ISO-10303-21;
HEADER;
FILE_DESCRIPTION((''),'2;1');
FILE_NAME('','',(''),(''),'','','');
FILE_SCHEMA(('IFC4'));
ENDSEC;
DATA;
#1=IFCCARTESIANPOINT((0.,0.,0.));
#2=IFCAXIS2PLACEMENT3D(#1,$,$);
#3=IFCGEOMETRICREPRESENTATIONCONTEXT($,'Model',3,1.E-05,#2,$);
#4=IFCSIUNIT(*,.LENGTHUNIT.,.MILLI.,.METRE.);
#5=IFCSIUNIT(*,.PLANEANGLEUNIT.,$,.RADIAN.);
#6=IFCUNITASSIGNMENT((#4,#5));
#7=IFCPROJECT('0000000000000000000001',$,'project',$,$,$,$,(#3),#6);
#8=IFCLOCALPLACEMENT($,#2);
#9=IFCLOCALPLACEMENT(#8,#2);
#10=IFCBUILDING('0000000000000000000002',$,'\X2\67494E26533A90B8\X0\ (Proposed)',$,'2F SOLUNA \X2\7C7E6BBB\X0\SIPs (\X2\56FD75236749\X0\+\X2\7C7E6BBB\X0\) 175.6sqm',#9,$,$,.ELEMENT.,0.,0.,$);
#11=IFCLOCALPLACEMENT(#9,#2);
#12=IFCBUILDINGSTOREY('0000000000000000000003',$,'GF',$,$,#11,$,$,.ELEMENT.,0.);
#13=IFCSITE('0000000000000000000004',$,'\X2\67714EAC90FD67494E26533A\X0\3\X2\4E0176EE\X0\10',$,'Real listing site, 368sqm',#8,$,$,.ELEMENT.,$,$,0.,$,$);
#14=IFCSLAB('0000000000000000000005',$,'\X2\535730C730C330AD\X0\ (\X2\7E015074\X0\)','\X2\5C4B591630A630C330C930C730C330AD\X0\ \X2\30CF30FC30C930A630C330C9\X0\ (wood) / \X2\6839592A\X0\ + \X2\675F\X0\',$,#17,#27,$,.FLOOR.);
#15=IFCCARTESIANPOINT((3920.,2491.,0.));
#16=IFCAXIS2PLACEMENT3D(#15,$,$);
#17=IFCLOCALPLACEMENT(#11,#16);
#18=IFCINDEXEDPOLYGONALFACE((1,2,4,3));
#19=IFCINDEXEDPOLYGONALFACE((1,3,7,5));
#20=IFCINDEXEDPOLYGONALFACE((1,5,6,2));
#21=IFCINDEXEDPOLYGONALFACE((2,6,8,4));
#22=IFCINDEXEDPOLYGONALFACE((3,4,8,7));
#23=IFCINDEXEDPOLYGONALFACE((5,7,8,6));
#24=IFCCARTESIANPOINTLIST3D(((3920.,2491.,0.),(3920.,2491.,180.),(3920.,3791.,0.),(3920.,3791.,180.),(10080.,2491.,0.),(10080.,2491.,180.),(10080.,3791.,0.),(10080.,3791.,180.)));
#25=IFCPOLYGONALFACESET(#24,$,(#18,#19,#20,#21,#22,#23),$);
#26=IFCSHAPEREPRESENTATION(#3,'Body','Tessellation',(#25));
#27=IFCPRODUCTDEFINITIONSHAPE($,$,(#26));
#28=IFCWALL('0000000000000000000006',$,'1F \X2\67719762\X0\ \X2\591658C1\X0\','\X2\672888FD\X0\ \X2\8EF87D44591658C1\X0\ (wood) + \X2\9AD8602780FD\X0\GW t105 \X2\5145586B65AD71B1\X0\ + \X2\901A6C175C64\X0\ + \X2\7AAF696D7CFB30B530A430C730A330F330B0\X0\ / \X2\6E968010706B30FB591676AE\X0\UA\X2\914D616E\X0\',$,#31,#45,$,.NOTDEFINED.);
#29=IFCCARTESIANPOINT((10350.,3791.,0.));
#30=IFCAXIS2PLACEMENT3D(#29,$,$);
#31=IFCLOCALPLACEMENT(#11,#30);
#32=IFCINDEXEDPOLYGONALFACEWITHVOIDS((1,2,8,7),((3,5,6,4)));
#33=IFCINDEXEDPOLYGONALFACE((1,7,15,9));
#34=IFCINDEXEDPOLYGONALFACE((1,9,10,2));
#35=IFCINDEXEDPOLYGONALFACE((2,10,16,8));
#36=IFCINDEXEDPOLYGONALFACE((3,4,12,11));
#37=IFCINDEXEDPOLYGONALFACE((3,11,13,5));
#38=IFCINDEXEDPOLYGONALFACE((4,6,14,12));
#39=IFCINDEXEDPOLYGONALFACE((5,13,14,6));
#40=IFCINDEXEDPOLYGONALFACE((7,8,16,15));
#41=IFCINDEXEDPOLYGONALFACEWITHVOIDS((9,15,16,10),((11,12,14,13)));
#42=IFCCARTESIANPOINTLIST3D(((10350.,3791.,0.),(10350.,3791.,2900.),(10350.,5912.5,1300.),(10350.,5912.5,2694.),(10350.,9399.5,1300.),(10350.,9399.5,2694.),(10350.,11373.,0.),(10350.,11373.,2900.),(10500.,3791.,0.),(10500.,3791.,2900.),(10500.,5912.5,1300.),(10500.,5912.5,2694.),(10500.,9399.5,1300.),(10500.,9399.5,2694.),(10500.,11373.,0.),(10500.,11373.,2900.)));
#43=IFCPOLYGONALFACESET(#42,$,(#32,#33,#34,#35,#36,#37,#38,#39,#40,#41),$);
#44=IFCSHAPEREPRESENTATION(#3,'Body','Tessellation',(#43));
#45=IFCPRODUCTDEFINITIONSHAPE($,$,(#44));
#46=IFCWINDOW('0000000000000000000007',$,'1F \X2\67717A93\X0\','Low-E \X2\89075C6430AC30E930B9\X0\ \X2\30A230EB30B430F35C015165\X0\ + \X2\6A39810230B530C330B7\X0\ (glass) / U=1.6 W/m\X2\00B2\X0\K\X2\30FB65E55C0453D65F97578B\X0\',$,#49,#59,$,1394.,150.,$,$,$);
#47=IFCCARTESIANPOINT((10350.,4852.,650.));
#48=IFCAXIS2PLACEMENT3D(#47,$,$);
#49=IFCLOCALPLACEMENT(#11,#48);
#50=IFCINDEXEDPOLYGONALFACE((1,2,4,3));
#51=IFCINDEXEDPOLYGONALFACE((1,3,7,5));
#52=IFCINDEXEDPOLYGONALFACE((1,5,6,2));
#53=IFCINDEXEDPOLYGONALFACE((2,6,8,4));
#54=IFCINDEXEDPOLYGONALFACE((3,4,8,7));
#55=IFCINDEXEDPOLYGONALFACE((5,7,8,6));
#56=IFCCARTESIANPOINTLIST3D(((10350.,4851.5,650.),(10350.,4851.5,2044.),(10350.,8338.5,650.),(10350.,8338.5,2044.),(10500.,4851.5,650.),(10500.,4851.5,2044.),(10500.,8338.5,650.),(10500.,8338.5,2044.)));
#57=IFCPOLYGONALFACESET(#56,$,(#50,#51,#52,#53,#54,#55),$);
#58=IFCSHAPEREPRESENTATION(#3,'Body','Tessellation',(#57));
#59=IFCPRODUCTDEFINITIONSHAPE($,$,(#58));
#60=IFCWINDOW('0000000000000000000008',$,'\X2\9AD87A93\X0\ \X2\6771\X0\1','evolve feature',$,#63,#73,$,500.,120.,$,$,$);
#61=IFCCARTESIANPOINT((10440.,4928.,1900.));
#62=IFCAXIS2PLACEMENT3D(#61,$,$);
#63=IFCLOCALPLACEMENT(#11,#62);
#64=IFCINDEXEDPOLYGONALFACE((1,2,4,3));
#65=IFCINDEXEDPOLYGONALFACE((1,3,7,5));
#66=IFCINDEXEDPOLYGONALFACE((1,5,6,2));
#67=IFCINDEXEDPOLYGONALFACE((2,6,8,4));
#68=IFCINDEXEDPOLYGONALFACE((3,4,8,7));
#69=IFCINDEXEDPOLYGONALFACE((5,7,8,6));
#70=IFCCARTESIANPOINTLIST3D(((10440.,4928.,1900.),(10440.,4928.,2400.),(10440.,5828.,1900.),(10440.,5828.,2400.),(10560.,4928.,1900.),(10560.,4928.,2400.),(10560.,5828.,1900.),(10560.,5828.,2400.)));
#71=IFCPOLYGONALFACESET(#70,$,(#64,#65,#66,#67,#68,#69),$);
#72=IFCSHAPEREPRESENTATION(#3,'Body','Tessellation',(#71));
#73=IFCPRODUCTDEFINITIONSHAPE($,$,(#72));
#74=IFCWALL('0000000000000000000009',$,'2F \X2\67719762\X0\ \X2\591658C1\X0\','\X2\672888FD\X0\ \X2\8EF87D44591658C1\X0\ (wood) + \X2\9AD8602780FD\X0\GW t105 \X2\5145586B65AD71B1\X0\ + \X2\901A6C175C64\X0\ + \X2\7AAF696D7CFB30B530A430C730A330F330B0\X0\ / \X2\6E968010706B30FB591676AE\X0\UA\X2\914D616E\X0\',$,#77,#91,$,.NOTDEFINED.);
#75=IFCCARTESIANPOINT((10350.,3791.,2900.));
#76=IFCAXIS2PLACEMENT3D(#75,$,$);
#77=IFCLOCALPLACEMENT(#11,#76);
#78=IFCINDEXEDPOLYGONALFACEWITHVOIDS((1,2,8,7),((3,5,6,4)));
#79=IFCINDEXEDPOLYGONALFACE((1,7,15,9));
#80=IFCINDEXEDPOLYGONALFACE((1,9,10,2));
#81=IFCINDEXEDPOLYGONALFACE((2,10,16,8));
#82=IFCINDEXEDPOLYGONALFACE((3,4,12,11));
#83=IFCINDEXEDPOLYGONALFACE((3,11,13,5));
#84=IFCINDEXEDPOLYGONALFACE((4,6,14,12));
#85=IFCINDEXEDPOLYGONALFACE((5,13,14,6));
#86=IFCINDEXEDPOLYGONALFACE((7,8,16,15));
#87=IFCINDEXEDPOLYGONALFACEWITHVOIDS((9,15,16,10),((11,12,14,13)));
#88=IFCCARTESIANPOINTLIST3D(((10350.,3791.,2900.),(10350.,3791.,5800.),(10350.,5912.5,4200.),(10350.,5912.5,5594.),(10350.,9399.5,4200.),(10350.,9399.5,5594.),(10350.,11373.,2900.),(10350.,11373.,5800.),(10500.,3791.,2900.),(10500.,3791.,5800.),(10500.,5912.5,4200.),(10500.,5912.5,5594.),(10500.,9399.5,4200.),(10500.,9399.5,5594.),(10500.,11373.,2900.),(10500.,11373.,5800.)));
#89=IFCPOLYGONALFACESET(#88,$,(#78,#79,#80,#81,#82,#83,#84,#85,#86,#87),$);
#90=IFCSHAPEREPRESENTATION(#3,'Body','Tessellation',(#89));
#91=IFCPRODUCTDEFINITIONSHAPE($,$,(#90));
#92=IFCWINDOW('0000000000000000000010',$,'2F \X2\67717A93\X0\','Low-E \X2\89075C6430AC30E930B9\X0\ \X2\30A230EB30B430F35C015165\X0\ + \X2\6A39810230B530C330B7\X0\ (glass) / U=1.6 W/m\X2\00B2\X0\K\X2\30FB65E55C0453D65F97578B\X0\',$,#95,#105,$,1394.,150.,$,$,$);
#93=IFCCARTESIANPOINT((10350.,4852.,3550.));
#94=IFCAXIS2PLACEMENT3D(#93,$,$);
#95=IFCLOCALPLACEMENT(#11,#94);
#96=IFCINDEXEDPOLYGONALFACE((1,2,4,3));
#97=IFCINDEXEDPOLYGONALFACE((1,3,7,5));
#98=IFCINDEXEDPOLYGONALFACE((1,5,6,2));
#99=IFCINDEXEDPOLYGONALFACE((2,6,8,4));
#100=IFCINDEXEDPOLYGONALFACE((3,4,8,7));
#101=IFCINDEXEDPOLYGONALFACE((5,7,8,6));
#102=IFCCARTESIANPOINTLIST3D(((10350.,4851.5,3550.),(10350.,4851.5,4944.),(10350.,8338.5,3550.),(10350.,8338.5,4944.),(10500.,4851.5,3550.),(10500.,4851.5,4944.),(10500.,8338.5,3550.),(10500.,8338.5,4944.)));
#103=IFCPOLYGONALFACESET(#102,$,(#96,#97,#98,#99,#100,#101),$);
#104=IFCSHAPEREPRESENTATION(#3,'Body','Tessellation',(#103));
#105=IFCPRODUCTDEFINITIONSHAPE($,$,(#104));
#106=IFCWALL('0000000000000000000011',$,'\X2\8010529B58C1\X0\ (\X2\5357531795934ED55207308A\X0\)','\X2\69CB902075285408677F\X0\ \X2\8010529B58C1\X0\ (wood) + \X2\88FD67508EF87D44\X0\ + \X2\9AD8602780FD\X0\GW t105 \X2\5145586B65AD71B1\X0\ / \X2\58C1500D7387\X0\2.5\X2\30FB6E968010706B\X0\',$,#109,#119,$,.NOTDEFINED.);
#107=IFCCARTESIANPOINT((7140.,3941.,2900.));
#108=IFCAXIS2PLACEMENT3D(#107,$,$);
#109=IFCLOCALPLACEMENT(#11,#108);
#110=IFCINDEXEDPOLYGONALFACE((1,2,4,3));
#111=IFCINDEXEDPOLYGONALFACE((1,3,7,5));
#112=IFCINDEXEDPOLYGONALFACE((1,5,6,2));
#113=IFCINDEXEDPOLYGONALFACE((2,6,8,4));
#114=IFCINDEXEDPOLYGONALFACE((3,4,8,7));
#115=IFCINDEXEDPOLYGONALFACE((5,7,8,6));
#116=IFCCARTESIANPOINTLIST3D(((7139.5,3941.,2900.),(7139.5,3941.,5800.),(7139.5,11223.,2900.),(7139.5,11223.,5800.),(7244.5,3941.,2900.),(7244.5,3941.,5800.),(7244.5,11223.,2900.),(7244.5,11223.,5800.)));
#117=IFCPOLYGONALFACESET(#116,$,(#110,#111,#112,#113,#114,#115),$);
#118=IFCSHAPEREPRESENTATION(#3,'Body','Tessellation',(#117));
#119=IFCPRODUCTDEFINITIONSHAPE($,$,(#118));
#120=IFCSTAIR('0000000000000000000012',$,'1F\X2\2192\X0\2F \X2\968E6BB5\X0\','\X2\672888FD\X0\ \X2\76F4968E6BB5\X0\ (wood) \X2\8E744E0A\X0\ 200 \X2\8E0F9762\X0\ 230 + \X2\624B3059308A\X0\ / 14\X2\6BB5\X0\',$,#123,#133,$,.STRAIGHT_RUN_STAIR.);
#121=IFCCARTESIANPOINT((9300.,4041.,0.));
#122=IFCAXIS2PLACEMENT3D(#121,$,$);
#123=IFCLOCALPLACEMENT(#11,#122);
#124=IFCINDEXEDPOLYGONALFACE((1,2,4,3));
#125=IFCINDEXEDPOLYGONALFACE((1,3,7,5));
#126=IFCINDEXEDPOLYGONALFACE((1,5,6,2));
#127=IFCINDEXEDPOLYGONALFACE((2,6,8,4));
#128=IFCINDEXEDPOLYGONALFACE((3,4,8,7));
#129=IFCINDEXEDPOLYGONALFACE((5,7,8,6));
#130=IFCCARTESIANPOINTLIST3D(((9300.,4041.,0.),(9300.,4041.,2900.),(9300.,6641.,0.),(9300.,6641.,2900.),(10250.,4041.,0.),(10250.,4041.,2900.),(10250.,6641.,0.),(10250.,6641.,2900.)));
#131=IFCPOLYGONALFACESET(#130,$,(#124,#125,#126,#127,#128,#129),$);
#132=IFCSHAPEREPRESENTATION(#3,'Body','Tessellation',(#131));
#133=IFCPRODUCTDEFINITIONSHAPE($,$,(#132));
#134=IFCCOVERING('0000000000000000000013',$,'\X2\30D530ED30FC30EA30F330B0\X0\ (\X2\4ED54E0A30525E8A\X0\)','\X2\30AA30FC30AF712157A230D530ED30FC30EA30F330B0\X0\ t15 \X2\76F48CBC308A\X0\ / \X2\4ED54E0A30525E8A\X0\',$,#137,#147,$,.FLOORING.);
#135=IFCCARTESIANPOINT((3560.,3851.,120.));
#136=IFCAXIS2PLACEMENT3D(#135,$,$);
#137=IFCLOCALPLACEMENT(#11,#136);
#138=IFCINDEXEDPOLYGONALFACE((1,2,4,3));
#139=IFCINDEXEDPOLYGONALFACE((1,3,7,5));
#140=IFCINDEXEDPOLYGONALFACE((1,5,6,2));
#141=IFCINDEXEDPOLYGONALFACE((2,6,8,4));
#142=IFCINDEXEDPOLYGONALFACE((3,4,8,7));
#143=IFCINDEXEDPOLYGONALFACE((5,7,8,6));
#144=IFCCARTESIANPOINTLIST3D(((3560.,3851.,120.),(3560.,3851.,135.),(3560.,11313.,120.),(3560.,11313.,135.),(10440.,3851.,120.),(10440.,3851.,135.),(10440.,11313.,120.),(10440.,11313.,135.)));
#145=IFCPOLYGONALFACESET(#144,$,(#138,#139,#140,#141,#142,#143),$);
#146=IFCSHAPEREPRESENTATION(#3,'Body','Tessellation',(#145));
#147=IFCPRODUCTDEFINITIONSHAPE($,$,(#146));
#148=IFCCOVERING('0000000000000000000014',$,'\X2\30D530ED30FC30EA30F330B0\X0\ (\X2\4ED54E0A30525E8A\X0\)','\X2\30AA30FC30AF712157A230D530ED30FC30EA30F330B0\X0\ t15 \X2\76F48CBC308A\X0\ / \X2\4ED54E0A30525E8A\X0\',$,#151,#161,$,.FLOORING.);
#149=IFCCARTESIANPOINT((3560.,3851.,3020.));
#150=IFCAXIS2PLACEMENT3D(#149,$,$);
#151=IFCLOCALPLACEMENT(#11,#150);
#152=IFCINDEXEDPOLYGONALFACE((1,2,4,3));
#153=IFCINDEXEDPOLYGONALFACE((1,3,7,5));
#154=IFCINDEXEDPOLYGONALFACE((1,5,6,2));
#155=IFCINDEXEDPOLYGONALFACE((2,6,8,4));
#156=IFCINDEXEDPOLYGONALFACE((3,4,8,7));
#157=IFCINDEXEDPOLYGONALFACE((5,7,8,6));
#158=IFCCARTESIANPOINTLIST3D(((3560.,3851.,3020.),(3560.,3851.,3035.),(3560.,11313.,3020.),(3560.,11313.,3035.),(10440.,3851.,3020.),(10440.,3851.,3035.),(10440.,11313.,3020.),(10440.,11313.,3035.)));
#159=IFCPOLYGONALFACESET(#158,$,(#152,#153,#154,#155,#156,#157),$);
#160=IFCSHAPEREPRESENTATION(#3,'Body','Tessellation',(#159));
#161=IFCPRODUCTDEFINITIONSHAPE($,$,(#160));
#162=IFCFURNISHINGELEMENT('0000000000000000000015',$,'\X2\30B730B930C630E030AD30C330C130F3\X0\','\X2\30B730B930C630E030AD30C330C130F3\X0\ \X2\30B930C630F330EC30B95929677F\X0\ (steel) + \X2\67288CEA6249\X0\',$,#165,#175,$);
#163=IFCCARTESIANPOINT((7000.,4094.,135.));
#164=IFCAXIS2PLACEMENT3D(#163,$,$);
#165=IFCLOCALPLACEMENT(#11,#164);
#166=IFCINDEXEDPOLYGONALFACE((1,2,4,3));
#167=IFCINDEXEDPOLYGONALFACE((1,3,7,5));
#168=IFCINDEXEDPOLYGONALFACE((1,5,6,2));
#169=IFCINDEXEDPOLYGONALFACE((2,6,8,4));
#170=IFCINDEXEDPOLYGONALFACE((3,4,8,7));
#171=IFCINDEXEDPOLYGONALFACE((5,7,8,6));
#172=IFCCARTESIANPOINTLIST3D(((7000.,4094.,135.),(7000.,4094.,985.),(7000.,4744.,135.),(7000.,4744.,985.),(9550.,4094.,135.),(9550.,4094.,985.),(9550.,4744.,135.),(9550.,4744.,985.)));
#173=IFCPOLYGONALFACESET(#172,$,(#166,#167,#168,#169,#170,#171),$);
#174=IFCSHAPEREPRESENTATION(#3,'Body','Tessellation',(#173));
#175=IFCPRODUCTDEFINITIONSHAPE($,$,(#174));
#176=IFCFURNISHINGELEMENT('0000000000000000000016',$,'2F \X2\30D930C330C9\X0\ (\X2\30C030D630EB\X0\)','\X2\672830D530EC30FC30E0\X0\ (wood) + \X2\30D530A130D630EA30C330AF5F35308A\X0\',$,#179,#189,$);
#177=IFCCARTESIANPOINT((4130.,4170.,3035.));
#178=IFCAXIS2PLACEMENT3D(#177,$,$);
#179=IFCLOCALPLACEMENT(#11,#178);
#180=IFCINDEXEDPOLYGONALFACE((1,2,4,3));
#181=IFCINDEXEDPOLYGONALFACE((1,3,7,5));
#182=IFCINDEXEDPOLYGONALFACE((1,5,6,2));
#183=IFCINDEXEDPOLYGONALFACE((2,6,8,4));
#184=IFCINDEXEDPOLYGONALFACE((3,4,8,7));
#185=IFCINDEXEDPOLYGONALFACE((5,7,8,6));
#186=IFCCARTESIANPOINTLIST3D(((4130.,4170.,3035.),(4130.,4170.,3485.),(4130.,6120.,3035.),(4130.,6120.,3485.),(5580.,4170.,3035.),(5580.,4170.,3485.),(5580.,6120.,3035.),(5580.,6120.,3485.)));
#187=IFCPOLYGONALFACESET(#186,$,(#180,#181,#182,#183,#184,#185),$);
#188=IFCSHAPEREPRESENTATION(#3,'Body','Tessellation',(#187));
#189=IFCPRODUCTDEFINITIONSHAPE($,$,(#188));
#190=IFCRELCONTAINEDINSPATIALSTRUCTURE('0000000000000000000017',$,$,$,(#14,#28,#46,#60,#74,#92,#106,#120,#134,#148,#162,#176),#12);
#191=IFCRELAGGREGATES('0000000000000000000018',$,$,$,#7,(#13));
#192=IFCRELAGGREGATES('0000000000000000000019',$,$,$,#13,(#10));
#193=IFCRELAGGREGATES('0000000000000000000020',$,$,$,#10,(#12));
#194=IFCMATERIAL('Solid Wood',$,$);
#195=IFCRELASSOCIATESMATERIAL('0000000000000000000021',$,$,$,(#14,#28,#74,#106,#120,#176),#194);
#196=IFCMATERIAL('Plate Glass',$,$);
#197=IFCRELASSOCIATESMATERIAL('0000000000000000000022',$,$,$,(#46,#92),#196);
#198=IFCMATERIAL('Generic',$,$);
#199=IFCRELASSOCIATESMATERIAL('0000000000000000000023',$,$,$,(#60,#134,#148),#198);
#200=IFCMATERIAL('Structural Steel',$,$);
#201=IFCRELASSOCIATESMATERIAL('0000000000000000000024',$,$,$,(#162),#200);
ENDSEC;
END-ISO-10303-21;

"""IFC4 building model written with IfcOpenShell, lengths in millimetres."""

from ifc_helpers import new_model, si_unit, frame, frame_2d, origin, place, context, project, spatial, rectangle, extrude, material, element, fill, save


model = new_model("IFC4")

# Units and contexts
model_context = context("Model", 3, precision=1e-05, world=origin())
ifc_project = project(units=[si_unit("LENGTHUNIT", "METRE", prefix="MILLI"), si_unit("PLANEANGLEUNIT", "RADIAN")], contexts=[model_context])

# Site, building, storey
site_placement = place(None, origin())
site = spatial("IfcSite", under=ifc_project, at=site_placement, Name="東京都杉並区3丁目10", ObjectType="Real listing site, 368sqm", CompositionType="ELEMENT", RefElevation=0.0)
building_placement = place(site_placement, origin())
building = spatial("IfcBuilding", under=site, at=building_placement, Name="杉並区邸 (Proposed)", ObjectType="2F SOLUNA 籾殻SIPs (国産杉+籾殻) 175.6sqm", CompositionType="ELEMENT", ElevationOfRefHeight=0.0, ElevationOfTerrain=0.0)
storey_placement = place(building_placement, origin())
storey = spatial("IfcBuildingStorey", under=building, at=storey_placement, Name="GF", CompositionType="ELEMENT", Elevation=0.0)

# Slab
ifc_material_1 = material(Name="Solid Wood")
slab_placement = place(storey_placement, frame((3920.0, 2491.0, 0.0)))
element("IfcSlab", 1, at=slab_placement, inside=storey, material=ifc_material_1, Name="南デッキ (縁側)", Description="屋外ウッドデッキ ハードウッド (wood) / 根太 + 束", PredefinedType="FLOOR", context=model_context, shape_type="SweptSolid", body=[
    extrude(rectangle(XDim=6160.0, YDim=1300.0, at=frame_2d((3080.0, 650.0))), frame((3920.0, 2491.0, 0.0)), (0.0, 0.0, 1.0), 180.0),
])

# Wall, openings, windows
wall_1_placement = place(storey_placement, frame((10350.0, 3791.0, 0.0)))
wall_1 = element("IfcWall", 2, at=wall_1_placement, inside=storey, material=ifc_material_1, Name="1F 東面 外壁", Description="木製 軸組外壁 (wood) + 高性能GW t105 充填断熱 + 通気層 + 窯業系サイディング / 準耐火・外皮UA配慮", PredefinedType="NOTDEFINED", context=model_context, shape_type="SweptSolid", body=[
    extrude(rectangle(XDim=150.0, YDim=7582.0, at=frame_2d((75.0, 3791.0))), frame((10350.0, 3791.0, 0.0)), (0.0, 0.0, 1.0), 2900.0),
])
opening_1_placement = place(storey_placement, frame((10350.0, 4852.0, 650.0)))
opening_1 = element("IfcOpeningElement", 3, at=opening_1_placement, cuts=wall_1, PredefinedType="NOTDEFINED", context=model_context, shape_type="SweptSolid", body=[
    extrude(rectangle(XDim=150.0, YDim=3487.0, at=frame_2d((75.0, 1743.0))), frame((10350.0, 4852.0, 650.0)), (0.0, 0.0, 1.0), 1394.0),
])
opening_2_placement = place(storey_placement, frame((10440.0, 4928.0, 1900.0)))
opening_2 = element("IfcOpeningElement", 4, at=opening_2_placement, cuts=wall_1, PredefinedType="NOTDEFINED", context=model_context, shape_type="SweptSolid", body=[
    extrude(rectangle(XDim=120.0, YDim=900.0, at=frame_2d((60.0, 450.0))), frame((10440.0, 4928.0, 1900.0)), (0.0, 0.0, 1.0), 500.0),
])
ifc_material_2 = material(Name="Plate Glass")
window_1_placement = place(storey_placement, frame((10350.0, 4852.0, 650.0)))
window_1 = element("IfcWindow", 5, at=window_1_placement, inside=storey, material=ifc_material_2, Name="1F 東窓", Description="Low-E 複層ガラス アルゴン封入 + 樹脂サッシ (glass) / U=1.6 W/m²K・日射取得型", OverallHeight=1394.0, OverallWidth=150.0, context=model_context, shape_type="SweptSolid", body=[
    extrude(rectangle(XDim=150.0, YDim=3487.0, at=frame_2d((75.0, 1743.0))), frame((10350.0, 4852.0, 650.0)), (0.0, 0.0, 1.0), 1394.0),
])
fill(opening_1, window_1)
ifc_material_3 = material(Name="Generic")
window_2_placement = place(storey_placement, frame((10440.0, 4928.0, 1900.0)))
window_2 = element("IfcWindow", 6, at=window_2_placement, inside=storey, material=ifc_material_3, Name="高窓 東1", Description="evolve feature", OverallHeight=500.0, OverallWidth=120.0, context=model_context, shape_type="SweptSolid", body=[
    extrude(rectangle(XDim=120.0, YDim=900.0, at=frame_2d((60.0, 450.0))), frame((10440.0, 4928.0, 1900.0)), (0.0, 0.0, 1.0), 500.0),
])
fill(opening_2, window_2)

# Wall, opening, window
wall_2_placement = place(storey_placement, frame((10350.0, 3791.0, 2900.0)))
wall_2 = element("IfcWall", 7, at=wall_2_placement, inside=storey, material=ifc_material_1, Name="2F 東面 外壁", Description="木製 軸組外壁 (wood) + 高性能GW t105 充填断熱 + 通気層 + 窯業系サイディング / 準耐火・外皮UA配慮", PredefinedType="NOTDEFINED", context=model_context, shape_type="SweptSolid", body=[
    extrude(rectangle(XDim=150.0, YDim=7582.0, at=frame_2d((75.0, 3791.0))), frame((10350.0, 3791.0, 2900.0)), (0.0, 0.0, 1.0), 2900.0),
])
opening_3_placement = place(storey_placement, frame((10350.0, 4852.0, 3550.0)))
opening_3 = element("IfcOpeningElement", 8, at=opening_3_placement, cuts=wall_2, PredefinedType="NOTDEFINED", context=model_context, shape_type="SweptSolid", body=[
    extrude(rectangle(XDim=150.0, YDim=3487.0, at=frame_2d((75.0, 1743.0))), frame((10350.0, 4852.0, 3550.0)), (0.0, 0.0, 1.0), 1394.0),
])
window_3_placement = place(storey_placement, frame((10350.0, 4852.0, 3550.0)))
window_3 = element("IfcWindow", 9, at=window_3_placement, inside=storey, material=ifc_material_2, Name="2F 東窓", Description="Low-E 複層ガラス アルゴン封入 + 樹脂サッシ (glass) / U=1.6 W/m²K・日射取得型", OverallHeight=1394.0, OverallWidth=150.0, context=model_context, shape_type="SweptSolid", body=[
    extrude(rectangle(XDim=150.0, YDim=3487.0, at=frame_2d((75.0, 1743.0))), frame((10350.0, 4852.0, 3550.0)), (0.0, 0.0, 1.0), 1394.0),
])
fill(opening_3, window_3)

# Wall
wall_3_placement = place(storey_placement, frame((7140.0, 3941.0, 2900.0)))
element("IfcWall", 10, at=wall_3_placement, inside=storey, material=ifc_material_1, Name="耐力壁 (南北間仕切り)", Description="構造用合板 耐力壁 (wood) + 製材軸組 + 高性能GW t105 充填断熱 / 壁倍率2.5・準耐火", PredefinedType="NOTDEFINED", context=model_context, shape_type="SweptSolid", body=[
    extrude(rectangle(XDim=105.0, YDim=7282.0, at=frame_2d((52.0, 3641.0))), frame((7140.0, 3941.0, 2900.0)), (0.0, 0.0, 1.0), 2900.0),
])

# Stair
stair_placement = place(storey_placement, frame((9300.0, 4041.0, 0.0)))
element("IfcStair", 11, at=stair_placement, inside=storey, material=ifc_material_1, Name="1F→2F 階段", Description="木製 直階段 (wood) 蹴上 200 踏面 230 + 手すり / 14段", PredefinedType="STRAIGHT_RUN_STAIR", context=model_context, shape_type="SweptSolid", body=[
    extrude(rectangle(XDim=950.0, YDim=2600.0, at=frame_2d((475.0, 1300.0))), frame((9300.0, 4041.0, 0.0)), (0.0, 0.0, 1.0), 2900.0),
])

# Coverings
covering_1_placement = place(storey_placement, frame((3560.0, 3851.0, 120.0)))
element("IfcCovering", 12, at=covering_1_placement, inside=storey, material=ifc_material_3, Name="フローリング (仕上げ床)", Description="オーク無垢フローリング t15 直貼り / 仕上げ床", PredefinedType="FLOORING", context=model_context, shape_type="SweptSolid", body=[
    extrude(rectangle(XDim=6880.0, YDim=7462.0, at=frame_2d((3440.0, 3731.0))), frame((3560.0, 3851.0, 120.0)), (0.0, 0.0, 1.0), 15.0),
])
covering_2_placement = place(storey_placement, frame((3560.0, 3851.0, 3020.0)))
element("IfcCovering", 13, at=covering_2_placement, inside=storey, material=ifc_material_3, Name="フローリング (仕上げ床)", Description="オーク無垢フローリング t15 直貼り / 仕上げ床", PredefinedType="FLOORING", context=model_context, shape_type="SweptSolid", body=[
    extrude(rectangle(XDim=6880.0, YDim=7462.0, at=frame_2d((3440.0, 3731.0))), frame((3560.0, 3851.0, 3020.0)), (0.0, 0.0, 1.0), 15.0),
])

# Furnishing elements
ifc_material_4 = material(Name="Structural Steel")
furnishing_1_placement = place(storey_placement, frame((7000.0, 4094.0, 135.0)))
element("IfcFurnishingElement", 14, at=furnishing_1_placement, inside=storey, material=ifc_material_4, Name="システムキッチン", Description="システムキッチン ステンレス天板 (steel) + 木質扉", context=model_context, shape_type="SweptSolid", body=[
    extrude(rectangle(XDim=2550.0, YDim=650.0, at=frame_2d((1275.0, 325.0))), frame((7000.0, 4094.0, 135.0)), (0.0, 0.0, 1.0), 850.0),
])
furnishing_2_placement = place(storey_placement, frame((4130.0, 4170.0, 3035.0)))
element("IfcFurnishingElement", 15, at=furnishing_2_placement, inside=storey, material=ifc_material_1, Name="2F ベッド (ダブル)", Description="木フレーム (wood) + ファブリック張り", context=model_context, shape_type="SweptSolid", body=[
    extrude(rectangle(XDim=1450.0, YDim=1950.0, at=frame_2d((725.0, 975.0))), frame((4130.0, 4170.0, 3035.0)), (0.0, 0.0, 1.0), 450.0),
])

save(model, "model.ifc")
